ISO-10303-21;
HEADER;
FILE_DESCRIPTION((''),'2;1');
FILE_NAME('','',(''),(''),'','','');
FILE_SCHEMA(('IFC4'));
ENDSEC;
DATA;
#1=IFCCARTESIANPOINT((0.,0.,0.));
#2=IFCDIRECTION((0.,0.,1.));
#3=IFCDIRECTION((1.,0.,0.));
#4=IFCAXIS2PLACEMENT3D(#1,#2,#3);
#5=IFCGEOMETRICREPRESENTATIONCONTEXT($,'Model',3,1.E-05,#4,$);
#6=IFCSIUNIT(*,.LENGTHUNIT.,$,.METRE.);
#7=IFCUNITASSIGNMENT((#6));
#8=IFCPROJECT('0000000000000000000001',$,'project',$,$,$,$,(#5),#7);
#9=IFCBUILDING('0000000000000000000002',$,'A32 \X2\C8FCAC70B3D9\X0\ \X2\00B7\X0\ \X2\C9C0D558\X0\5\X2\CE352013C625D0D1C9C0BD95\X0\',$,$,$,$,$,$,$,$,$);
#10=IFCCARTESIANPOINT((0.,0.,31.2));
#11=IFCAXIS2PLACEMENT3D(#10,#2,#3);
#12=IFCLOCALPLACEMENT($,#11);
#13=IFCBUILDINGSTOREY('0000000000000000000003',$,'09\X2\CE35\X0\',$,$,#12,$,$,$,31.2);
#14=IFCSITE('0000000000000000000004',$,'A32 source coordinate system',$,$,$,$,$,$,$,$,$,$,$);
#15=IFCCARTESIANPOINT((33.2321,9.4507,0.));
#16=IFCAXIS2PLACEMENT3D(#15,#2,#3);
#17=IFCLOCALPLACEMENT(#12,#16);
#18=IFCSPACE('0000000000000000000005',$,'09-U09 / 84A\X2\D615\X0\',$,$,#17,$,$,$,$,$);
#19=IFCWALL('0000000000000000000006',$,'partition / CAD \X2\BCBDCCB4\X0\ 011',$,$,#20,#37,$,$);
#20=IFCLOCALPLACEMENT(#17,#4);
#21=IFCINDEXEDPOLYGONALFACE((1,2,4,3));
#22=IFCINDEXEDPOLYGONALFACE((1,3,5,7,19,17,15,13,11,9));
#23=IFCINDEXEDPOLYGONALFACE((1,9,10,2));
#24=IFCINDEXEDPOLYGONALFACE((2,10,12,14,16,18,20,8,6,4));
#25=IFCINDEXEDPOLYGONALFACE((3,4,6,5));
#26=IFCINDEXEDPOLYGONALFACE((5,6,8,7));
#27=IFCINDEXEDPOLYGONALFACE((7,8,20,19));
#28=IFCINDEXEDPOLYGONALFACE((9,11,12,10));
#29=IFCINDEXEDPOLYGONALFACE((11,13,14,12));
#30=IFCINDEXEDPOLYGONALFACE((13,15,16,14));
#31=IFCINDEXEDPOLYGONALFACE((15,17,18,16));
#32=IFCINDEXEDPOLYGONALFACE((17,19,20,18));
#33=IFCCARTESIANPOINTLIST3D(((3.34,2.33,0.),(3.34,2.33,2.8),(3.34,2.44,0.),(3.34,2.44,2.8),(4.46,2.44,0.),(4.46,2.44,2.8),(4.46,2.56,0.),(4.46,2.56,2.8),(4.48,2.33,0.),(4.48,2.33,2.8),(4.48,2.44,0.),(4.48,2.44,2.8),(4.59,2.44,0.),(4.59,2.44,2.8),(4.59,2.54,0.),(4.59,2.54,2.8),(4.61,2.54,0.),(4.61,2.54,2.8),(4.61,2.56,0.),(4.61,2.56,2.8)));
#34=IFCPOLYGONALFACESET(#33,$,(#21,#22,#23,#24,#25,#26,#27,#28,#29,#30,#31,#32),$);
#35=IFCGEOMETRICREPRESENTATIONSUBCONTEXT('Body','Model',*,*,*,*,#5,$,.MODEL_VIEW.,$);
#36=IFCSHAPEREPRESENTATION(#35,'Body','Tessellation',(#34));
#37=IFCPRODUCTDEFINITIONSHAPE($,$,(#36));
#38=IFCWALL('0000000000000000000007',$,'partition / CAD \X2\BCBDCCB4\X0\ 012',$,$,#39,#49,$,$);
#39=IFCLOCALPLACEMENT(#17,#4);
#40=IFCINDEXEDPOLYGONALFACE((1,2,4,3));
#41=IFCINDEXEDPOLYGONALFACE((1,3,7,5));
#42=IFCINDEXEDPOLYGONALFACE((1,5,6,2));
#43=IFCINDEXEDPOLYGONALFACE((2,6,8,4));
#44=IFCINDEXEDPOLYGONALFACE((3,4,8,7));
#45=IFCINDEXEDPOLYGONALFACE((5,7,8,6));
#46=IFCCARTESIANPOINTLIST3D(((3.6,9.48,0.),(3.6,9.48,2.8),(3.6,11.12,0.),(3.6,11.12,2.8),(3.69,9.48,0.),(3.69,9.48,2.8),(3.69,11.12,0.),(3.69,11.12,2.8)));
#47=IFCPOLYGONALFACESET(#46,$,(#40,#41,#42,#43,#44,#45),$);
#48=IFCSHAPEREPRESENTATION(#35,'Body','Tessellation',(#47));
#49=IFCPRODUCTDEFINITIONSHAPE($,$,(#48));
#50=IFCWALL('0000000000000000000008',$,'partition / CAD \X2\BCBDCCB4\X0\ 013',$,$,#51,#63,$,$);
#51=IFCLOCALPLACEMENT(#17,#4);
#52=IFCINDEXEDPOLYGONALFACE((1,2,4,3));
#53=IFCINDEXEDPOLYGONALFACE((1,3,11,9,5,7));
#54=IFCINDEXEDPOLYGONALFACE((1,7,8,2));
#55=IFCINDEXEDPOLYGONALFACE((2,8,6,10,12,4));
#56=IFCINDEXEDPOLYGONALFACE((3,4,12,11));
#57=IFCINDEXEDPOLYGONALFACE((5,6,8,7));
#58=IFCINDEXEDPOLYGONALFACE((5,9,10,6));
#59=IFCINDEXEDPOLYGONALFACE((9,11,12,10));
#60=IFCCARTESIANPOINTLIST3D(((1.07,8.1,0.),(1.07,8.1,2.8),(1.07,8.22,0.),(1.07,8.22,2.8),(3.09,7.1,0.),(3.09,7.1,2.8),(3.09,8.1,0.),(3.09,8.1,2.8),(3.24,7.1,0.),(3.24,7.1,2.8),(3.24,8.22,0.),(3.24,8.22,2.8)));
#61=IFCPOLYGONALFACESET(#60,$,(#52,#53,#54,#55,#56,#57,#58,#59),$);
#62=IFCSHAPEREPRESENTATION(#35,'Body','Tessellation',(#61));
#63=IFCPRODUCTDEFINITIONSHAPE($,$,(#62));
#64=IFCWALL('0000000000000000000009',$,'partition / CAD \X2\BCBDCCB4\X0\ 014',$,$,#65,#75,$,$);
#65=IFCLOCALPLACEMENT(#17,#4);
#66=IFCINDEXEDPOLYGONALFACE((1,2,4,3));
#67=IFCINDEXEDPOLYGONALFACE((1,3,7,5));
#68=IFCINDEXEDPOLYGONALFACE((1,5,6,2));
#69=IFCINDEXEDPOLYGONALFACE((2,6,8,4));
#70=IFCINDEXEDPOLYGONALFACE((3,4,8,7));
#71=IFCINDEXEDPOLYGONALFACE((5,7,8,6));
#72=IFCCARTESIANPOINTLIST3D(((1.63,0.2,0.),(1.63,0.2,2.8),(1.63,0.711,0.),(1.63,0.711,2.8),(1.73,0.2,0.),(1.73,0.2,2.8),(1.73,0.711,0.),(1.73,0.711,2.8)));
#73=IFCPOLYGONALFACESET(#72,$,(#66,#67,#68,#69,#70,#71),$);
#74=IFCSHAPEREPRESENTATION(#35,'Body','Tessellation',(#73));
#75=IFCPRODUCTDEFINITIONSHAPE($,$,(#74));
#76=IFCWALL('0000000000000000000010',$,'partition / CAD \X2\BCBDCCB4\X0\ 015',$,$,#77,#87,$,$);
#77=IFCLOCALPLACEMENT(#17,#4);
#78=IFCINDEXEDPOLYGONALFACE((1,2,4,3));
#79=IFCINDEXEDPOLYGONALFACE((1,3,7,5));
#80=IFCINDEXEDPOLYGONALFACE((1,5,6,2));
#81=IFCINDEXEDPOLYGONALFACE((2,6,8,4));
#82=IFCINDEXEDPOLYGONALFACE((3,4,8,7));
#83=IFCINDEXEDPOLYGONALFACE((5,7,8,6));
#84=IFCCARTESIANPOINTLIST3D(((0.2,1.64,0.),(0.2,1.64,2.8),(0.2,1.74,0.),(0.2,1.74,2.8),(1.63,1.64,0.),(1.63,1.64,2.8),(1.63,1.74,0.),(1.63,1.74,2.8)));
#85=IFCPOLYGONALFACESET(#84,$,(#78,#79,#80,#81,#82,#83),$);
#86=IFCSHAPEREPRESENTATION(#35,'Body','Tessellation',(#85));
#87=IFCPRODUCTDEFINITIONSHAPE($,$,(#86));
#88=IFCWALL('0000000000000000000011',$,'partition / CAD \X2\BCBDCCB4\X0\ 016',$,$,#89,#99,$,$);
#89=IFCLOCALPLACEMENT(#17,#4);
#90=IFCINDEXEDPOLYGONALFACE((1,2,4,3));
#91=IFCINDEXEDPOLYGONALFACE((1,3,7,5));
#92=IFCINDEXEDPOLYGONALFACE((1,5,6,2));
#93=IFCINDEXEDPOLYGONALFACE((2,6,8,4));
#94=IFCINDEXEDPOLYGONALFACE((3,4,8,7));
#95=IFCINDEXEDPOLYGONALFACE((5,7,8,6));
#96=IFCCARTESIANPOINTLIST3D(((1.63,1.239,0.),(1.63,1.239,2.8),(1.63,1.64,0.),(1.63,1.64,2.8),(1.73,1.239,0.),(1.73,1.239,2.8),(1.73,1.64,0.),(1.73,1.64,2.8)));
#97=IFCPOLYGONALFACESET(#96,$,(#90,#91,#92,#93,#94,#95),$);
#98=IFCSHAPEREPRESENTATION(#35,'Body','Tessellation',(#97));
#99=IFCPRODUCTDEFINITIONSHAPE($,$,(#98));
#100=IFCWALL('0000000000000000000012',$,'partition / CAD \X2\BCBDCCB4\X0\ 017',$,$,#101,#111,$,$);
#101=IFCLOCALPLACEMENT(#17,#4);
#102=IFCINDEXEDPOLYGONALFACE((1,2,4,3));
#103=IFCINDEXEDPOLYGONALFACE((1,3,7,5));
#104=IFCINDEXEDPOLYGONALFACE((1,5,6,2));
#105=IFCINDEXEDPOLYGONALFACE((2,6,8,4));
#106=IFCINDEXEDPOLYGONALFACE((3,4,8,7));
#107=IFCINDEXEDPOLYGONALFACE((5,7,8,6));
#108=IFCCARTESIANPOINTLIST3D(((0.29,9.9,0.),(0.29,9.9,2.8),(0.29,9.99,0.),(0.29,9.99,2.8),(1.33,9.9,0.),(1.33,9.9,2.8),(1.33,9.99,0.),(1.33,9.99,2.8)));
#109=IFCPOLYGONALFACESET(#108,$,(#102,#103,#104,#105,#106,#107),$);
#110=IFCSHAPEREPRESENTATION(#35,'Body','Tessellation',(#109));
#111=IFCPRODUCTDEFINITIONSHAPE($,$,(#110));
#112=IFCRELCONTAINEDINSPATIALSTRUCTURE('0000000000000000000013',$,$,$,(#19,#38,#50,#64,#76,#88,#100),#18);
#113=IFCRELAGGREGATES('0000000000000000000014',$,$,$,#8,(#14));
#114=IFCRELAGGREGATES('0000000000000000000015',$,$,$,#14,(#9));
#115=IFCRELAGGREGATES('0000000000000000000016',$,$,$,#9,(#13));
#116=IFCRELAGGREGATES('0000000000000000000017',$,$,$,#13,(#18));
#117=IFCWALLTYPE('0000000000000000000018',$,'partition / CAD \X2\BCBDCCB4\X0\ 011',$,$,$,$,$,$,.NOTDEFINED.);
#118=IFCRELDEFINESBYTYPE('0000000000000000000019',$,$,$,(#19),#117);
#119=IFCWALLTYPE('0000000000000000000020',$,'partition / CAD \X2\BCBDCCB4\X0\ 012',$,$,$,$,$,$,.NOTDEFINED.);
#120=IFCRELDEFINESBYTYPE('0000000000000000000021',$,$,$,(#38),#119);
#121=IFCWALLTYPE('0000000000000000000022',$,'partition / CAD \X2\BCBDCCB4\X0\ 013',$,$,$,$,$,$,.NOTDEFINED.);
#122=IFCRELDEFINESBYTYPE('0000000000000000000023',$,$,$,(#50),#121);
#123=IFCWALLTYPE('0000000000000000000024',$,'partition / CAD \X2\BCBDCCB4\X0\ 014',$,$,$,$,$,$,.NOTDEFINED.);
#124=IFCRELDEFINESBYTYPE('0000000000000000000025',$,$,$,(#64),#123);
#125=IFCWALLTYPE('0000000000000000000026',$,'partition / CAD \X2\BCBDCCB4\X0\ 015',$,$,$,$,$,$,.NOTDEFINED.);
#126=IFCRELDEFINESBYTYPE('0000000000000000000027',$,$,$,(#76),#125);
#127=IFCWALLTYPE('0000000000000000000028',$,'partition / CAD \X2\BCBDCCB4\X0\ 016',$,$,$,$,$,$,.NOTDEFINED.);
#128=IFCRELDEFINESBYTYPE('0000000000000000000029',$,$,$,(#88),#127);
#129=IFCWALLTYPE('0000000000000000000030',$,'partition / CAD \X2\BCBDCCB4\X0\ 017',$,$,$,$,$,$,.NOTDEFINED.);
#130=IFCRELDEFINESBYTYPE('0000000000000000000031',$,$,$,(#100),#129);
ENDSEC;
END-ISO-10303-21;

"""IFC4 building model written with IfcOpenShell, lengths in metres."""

from ifc_helpers import new_model, si_unit, frame, origin, origin_with_axes, place, context, subcontext, project, spatial, polyline, outline, extrude, source, transform, mapped, type_object, type_shapes, element, save


model = new_model("IFC4")

# Units and contexts
model_context = context("Model", 3, precision=1e-05, world=origin_with_axes())
body_context = subcontext(model_context, "Body", "Model", "MODEL_VIEW")
ifc_project = project(units=[si_unit("LENGTHUNIT", "METRE")], contexts=[model_context])

# Site, building, storey, space
storey_placement = place(None, frame((0.0, 0.0, 31.2), z_axis=(0.0, 0.0, 1.0), x_axis=(1.0, 0.0, 0.0)))
space_placement = place(storey_placement, frame((33.2321, 9.4507, 0.0), z_axis=(0.0, 0.0, 1.0), x_axis=(1.0, 0.0, 0.0)))
site = spatial("IfcSite", under=ifc_project, Name="A32 source coordinate system")
building = spatial("IfcBuilding", under=site, Name="A32 주거동 · 지하5층–옥탑지붕")
storey = spatial("IfcBuildingStorey", under=building, at=storey_placement, Name="09층", Elevation=31.2)
space = spatial("IfcSpace", under=storey, at=space_placement, Name="09-U09 / 84A형")

# Walls
wall_type_1 = type_object("IfcWallType", Name="partition / CAD 벽체 011", PredefinedType="NOTDEFINED")
shared_shape_1 = source(origin(), body_context, "Body", "SweptSolid", [
    extrude(outline(polyline([(3.34, 2.33), (3.34, 2.44), (4.46, 2.44), (4.46, 2.56), (4.61, 2.56), (4.61, 2.54), (4.59, 2.54), (4.59, 2.44), (4.48, 2.44), (4.48, 2.33), (3.34, 2.33)])), origin(), (0.0, 0.0, 1.0), 2.8),
])
type_shapes(wall_type_1, [shared_shape_1])
wall_1_placement = place(space_placement, origin_with_axes())
element("IfcWall", 1, at=wall_1_placement, inside=space, type_object=wall_type_1, Name="partition / CAD 벽체 011", context=body_context, shape_type="MappedRepresentation", body=[
    mapped(shared_shape_1, transform((0.0, 0.0, 0.0), scale=1.0)),
])
wall_type_2 = type_object("IfcWallType", Name="partition / CAD 벽체 012", PredefinedType="NOTDEFINED")
shared_shape_2 = source(origin(), body_context, "Body", "SweptSolid", [
    extrude(outline(polyline([(3.6, 11.12), (3.69, 11.12), (3.69, 9.48), (3.6, 9.48), (3.6, 11.12)])), origin(), (0.0, 0.0, 1.0), 2.8),
])
type_shapes(wall_type_2, [shared_shape_2])
wall_2_placement = place(space_placement, origin_with_axes())
element("IfcWall", 2, at=wall_2_placement, inside=space, type_object=wall_type_2, Name="partition / CAD 벽체 012", context=body_context, shape_type="MappedRepresentation", body=[
    mapped(shared_shape_2, transform((0.0, 0.0, 0.0), scale=1.0)),
])
wall_type_3 = type_object("IfcWallType", Name="partition / CAD 벽체 013", PredefinedType="NOTDEFINED")
shared_shape_3 = source(origin(), body_context, "Body", "SweptSolid", [
    extrude(outline(polyline([(3.09, 8.1), (1.07, 8.1), (1.07, 8.22), (3.24, 8.22), (3.24, 7.1), (3.09, 7.1), (3.09, 8.1)])), origin(), (0.0, 0.0, 1.0), 2.8),
])
type_shapes(wall_type_3, [shared_shape_3])
wall_3_placement = place(space_placement, origin_with_axes())
element("IfcWall", 3, at=wall_3_placement, inside=space, type_object=wall_type_3, Name="partition / CAD 벽체 013", context=body_context, shape_type="MappedRepresentation", body=[
    mapped(shared_shape_3, transform((0.0, 0.0, 0.0), scale=1.0)),
])
wall_type_4 = type_object("IfcWallType", Name="partition / CAD 벽체 014", PredefinedType="NOTDEFINED")
shared_shape_4 = source(origin(), body_context, "Body", "SweptSolid", [
    extrude(outline(polyline([(1.73, 0.2), (1.63, 0.2), (1.63, 0.711), (1.73, 0.711), (1.73, 0.2)])), origin(), (0.0, 0.0, 1.0), 2.8),
])
type_shapes(wall_type_4, [shared_shape_4])
wall_4_placement = place(space_placement, origin_with_axes())
element("IfcWall", 4, at=wall_4_placement, inside=space, type_object=wall_type_4, Name="partition / CAD 벽체 014", context=body_context, shape_type="MappedRepresentation", body=[
    mapped(shared_shape_4, transform((0.0, 0.0, 0.0), scale=1.0)),
])
wall_type_5 = type_object("IfcWallType", Name="partition / CAD 벽체 015", PredefinedType="NOTDEFINED")
shared_shape_5 = source(origin(), body_context, "Body", "SweptSolid", [
    extrude(outline(polyline([(1.63, 1.74), (1.63, 1.64), (0.2, 1.64), (0.2, 1.74), (1.63, 1.74)])), origin(), (0.0, 0.0, 1.0), 2.8),
])
type_shapes(wall_type_5, [shared_shape_5])
wall_5_placement = place(space_placement, origin_with_axes())
element("IfcWall", 5, at=wall_5_placement, inside=space, type_object=wall_type_5, Name="partition / CAD 벽체 015", context=body_context, shape_type="MappedRepresentation", body=[
    mapped(shared_shape_5, transform((0.0, 0.0, 0.0), scale=1.0)),
])
wall_type_6 = type_object("IfcWallType", Name="partition / CAD 벽체 016", PredefinedType="NOTDEFINED")
shared_shape_6 = source(origin(), body_context, "Body", "SweptSolid", [
    extrude(outline(polyline([(1.73, 1.239), (1.63, 1.239), (1.63, 1.64), (1.73, 1.64), (1.73, 1.239)])), origin(), (0.0, 0.0, 1.0), 2.8),
])
type_shapes(wall_type_6, [shared_shape_6])
wall_6_placement = place(space_placement, origin_with_axes())
element("IfcWall", 6, at=wall_6_placement, inside=space, type_object=wall_type_6, Name="partition / CAD 벽체 016", context=body_context, shape_type="MappedRepresentation", body=[
    mapped(shared_shape_6, transform((0.0, 0.0, 0.0), scale=1.0)),
])
wall_type_7 = type_object("IfcWallType", Name="partition / CAD 벽체 017", PredefinedType="NOTDEFINED")
shared_shape_7 = source(origin(), body_context, "Body", "SweptSolid", [
    extrude(outline(polyline([(1.33, 9.99), (1.33, 9.9), (0.29, 9.9), (0.29, 9.99), (1.33, 9.99)])), origin(), (0.0, 0.0, 1.0), 2.8),
])
type_shapes(wall_type_7, [shared_shape_7])
wall_7_placement = place(space_placement, origin_with_axes())
element("IfcWall", 7, at=wall_7_placement, inside=space, type_object=wall_type_7, Name="partition / CAD 벽체 017", context=body_context, shape_type="MappedRepresentation", body=[
    mapped(shared_shape_7, transform((0.0, 0.0, 0.0), scale=1.0)),
])

save(model, "model.ifc")
